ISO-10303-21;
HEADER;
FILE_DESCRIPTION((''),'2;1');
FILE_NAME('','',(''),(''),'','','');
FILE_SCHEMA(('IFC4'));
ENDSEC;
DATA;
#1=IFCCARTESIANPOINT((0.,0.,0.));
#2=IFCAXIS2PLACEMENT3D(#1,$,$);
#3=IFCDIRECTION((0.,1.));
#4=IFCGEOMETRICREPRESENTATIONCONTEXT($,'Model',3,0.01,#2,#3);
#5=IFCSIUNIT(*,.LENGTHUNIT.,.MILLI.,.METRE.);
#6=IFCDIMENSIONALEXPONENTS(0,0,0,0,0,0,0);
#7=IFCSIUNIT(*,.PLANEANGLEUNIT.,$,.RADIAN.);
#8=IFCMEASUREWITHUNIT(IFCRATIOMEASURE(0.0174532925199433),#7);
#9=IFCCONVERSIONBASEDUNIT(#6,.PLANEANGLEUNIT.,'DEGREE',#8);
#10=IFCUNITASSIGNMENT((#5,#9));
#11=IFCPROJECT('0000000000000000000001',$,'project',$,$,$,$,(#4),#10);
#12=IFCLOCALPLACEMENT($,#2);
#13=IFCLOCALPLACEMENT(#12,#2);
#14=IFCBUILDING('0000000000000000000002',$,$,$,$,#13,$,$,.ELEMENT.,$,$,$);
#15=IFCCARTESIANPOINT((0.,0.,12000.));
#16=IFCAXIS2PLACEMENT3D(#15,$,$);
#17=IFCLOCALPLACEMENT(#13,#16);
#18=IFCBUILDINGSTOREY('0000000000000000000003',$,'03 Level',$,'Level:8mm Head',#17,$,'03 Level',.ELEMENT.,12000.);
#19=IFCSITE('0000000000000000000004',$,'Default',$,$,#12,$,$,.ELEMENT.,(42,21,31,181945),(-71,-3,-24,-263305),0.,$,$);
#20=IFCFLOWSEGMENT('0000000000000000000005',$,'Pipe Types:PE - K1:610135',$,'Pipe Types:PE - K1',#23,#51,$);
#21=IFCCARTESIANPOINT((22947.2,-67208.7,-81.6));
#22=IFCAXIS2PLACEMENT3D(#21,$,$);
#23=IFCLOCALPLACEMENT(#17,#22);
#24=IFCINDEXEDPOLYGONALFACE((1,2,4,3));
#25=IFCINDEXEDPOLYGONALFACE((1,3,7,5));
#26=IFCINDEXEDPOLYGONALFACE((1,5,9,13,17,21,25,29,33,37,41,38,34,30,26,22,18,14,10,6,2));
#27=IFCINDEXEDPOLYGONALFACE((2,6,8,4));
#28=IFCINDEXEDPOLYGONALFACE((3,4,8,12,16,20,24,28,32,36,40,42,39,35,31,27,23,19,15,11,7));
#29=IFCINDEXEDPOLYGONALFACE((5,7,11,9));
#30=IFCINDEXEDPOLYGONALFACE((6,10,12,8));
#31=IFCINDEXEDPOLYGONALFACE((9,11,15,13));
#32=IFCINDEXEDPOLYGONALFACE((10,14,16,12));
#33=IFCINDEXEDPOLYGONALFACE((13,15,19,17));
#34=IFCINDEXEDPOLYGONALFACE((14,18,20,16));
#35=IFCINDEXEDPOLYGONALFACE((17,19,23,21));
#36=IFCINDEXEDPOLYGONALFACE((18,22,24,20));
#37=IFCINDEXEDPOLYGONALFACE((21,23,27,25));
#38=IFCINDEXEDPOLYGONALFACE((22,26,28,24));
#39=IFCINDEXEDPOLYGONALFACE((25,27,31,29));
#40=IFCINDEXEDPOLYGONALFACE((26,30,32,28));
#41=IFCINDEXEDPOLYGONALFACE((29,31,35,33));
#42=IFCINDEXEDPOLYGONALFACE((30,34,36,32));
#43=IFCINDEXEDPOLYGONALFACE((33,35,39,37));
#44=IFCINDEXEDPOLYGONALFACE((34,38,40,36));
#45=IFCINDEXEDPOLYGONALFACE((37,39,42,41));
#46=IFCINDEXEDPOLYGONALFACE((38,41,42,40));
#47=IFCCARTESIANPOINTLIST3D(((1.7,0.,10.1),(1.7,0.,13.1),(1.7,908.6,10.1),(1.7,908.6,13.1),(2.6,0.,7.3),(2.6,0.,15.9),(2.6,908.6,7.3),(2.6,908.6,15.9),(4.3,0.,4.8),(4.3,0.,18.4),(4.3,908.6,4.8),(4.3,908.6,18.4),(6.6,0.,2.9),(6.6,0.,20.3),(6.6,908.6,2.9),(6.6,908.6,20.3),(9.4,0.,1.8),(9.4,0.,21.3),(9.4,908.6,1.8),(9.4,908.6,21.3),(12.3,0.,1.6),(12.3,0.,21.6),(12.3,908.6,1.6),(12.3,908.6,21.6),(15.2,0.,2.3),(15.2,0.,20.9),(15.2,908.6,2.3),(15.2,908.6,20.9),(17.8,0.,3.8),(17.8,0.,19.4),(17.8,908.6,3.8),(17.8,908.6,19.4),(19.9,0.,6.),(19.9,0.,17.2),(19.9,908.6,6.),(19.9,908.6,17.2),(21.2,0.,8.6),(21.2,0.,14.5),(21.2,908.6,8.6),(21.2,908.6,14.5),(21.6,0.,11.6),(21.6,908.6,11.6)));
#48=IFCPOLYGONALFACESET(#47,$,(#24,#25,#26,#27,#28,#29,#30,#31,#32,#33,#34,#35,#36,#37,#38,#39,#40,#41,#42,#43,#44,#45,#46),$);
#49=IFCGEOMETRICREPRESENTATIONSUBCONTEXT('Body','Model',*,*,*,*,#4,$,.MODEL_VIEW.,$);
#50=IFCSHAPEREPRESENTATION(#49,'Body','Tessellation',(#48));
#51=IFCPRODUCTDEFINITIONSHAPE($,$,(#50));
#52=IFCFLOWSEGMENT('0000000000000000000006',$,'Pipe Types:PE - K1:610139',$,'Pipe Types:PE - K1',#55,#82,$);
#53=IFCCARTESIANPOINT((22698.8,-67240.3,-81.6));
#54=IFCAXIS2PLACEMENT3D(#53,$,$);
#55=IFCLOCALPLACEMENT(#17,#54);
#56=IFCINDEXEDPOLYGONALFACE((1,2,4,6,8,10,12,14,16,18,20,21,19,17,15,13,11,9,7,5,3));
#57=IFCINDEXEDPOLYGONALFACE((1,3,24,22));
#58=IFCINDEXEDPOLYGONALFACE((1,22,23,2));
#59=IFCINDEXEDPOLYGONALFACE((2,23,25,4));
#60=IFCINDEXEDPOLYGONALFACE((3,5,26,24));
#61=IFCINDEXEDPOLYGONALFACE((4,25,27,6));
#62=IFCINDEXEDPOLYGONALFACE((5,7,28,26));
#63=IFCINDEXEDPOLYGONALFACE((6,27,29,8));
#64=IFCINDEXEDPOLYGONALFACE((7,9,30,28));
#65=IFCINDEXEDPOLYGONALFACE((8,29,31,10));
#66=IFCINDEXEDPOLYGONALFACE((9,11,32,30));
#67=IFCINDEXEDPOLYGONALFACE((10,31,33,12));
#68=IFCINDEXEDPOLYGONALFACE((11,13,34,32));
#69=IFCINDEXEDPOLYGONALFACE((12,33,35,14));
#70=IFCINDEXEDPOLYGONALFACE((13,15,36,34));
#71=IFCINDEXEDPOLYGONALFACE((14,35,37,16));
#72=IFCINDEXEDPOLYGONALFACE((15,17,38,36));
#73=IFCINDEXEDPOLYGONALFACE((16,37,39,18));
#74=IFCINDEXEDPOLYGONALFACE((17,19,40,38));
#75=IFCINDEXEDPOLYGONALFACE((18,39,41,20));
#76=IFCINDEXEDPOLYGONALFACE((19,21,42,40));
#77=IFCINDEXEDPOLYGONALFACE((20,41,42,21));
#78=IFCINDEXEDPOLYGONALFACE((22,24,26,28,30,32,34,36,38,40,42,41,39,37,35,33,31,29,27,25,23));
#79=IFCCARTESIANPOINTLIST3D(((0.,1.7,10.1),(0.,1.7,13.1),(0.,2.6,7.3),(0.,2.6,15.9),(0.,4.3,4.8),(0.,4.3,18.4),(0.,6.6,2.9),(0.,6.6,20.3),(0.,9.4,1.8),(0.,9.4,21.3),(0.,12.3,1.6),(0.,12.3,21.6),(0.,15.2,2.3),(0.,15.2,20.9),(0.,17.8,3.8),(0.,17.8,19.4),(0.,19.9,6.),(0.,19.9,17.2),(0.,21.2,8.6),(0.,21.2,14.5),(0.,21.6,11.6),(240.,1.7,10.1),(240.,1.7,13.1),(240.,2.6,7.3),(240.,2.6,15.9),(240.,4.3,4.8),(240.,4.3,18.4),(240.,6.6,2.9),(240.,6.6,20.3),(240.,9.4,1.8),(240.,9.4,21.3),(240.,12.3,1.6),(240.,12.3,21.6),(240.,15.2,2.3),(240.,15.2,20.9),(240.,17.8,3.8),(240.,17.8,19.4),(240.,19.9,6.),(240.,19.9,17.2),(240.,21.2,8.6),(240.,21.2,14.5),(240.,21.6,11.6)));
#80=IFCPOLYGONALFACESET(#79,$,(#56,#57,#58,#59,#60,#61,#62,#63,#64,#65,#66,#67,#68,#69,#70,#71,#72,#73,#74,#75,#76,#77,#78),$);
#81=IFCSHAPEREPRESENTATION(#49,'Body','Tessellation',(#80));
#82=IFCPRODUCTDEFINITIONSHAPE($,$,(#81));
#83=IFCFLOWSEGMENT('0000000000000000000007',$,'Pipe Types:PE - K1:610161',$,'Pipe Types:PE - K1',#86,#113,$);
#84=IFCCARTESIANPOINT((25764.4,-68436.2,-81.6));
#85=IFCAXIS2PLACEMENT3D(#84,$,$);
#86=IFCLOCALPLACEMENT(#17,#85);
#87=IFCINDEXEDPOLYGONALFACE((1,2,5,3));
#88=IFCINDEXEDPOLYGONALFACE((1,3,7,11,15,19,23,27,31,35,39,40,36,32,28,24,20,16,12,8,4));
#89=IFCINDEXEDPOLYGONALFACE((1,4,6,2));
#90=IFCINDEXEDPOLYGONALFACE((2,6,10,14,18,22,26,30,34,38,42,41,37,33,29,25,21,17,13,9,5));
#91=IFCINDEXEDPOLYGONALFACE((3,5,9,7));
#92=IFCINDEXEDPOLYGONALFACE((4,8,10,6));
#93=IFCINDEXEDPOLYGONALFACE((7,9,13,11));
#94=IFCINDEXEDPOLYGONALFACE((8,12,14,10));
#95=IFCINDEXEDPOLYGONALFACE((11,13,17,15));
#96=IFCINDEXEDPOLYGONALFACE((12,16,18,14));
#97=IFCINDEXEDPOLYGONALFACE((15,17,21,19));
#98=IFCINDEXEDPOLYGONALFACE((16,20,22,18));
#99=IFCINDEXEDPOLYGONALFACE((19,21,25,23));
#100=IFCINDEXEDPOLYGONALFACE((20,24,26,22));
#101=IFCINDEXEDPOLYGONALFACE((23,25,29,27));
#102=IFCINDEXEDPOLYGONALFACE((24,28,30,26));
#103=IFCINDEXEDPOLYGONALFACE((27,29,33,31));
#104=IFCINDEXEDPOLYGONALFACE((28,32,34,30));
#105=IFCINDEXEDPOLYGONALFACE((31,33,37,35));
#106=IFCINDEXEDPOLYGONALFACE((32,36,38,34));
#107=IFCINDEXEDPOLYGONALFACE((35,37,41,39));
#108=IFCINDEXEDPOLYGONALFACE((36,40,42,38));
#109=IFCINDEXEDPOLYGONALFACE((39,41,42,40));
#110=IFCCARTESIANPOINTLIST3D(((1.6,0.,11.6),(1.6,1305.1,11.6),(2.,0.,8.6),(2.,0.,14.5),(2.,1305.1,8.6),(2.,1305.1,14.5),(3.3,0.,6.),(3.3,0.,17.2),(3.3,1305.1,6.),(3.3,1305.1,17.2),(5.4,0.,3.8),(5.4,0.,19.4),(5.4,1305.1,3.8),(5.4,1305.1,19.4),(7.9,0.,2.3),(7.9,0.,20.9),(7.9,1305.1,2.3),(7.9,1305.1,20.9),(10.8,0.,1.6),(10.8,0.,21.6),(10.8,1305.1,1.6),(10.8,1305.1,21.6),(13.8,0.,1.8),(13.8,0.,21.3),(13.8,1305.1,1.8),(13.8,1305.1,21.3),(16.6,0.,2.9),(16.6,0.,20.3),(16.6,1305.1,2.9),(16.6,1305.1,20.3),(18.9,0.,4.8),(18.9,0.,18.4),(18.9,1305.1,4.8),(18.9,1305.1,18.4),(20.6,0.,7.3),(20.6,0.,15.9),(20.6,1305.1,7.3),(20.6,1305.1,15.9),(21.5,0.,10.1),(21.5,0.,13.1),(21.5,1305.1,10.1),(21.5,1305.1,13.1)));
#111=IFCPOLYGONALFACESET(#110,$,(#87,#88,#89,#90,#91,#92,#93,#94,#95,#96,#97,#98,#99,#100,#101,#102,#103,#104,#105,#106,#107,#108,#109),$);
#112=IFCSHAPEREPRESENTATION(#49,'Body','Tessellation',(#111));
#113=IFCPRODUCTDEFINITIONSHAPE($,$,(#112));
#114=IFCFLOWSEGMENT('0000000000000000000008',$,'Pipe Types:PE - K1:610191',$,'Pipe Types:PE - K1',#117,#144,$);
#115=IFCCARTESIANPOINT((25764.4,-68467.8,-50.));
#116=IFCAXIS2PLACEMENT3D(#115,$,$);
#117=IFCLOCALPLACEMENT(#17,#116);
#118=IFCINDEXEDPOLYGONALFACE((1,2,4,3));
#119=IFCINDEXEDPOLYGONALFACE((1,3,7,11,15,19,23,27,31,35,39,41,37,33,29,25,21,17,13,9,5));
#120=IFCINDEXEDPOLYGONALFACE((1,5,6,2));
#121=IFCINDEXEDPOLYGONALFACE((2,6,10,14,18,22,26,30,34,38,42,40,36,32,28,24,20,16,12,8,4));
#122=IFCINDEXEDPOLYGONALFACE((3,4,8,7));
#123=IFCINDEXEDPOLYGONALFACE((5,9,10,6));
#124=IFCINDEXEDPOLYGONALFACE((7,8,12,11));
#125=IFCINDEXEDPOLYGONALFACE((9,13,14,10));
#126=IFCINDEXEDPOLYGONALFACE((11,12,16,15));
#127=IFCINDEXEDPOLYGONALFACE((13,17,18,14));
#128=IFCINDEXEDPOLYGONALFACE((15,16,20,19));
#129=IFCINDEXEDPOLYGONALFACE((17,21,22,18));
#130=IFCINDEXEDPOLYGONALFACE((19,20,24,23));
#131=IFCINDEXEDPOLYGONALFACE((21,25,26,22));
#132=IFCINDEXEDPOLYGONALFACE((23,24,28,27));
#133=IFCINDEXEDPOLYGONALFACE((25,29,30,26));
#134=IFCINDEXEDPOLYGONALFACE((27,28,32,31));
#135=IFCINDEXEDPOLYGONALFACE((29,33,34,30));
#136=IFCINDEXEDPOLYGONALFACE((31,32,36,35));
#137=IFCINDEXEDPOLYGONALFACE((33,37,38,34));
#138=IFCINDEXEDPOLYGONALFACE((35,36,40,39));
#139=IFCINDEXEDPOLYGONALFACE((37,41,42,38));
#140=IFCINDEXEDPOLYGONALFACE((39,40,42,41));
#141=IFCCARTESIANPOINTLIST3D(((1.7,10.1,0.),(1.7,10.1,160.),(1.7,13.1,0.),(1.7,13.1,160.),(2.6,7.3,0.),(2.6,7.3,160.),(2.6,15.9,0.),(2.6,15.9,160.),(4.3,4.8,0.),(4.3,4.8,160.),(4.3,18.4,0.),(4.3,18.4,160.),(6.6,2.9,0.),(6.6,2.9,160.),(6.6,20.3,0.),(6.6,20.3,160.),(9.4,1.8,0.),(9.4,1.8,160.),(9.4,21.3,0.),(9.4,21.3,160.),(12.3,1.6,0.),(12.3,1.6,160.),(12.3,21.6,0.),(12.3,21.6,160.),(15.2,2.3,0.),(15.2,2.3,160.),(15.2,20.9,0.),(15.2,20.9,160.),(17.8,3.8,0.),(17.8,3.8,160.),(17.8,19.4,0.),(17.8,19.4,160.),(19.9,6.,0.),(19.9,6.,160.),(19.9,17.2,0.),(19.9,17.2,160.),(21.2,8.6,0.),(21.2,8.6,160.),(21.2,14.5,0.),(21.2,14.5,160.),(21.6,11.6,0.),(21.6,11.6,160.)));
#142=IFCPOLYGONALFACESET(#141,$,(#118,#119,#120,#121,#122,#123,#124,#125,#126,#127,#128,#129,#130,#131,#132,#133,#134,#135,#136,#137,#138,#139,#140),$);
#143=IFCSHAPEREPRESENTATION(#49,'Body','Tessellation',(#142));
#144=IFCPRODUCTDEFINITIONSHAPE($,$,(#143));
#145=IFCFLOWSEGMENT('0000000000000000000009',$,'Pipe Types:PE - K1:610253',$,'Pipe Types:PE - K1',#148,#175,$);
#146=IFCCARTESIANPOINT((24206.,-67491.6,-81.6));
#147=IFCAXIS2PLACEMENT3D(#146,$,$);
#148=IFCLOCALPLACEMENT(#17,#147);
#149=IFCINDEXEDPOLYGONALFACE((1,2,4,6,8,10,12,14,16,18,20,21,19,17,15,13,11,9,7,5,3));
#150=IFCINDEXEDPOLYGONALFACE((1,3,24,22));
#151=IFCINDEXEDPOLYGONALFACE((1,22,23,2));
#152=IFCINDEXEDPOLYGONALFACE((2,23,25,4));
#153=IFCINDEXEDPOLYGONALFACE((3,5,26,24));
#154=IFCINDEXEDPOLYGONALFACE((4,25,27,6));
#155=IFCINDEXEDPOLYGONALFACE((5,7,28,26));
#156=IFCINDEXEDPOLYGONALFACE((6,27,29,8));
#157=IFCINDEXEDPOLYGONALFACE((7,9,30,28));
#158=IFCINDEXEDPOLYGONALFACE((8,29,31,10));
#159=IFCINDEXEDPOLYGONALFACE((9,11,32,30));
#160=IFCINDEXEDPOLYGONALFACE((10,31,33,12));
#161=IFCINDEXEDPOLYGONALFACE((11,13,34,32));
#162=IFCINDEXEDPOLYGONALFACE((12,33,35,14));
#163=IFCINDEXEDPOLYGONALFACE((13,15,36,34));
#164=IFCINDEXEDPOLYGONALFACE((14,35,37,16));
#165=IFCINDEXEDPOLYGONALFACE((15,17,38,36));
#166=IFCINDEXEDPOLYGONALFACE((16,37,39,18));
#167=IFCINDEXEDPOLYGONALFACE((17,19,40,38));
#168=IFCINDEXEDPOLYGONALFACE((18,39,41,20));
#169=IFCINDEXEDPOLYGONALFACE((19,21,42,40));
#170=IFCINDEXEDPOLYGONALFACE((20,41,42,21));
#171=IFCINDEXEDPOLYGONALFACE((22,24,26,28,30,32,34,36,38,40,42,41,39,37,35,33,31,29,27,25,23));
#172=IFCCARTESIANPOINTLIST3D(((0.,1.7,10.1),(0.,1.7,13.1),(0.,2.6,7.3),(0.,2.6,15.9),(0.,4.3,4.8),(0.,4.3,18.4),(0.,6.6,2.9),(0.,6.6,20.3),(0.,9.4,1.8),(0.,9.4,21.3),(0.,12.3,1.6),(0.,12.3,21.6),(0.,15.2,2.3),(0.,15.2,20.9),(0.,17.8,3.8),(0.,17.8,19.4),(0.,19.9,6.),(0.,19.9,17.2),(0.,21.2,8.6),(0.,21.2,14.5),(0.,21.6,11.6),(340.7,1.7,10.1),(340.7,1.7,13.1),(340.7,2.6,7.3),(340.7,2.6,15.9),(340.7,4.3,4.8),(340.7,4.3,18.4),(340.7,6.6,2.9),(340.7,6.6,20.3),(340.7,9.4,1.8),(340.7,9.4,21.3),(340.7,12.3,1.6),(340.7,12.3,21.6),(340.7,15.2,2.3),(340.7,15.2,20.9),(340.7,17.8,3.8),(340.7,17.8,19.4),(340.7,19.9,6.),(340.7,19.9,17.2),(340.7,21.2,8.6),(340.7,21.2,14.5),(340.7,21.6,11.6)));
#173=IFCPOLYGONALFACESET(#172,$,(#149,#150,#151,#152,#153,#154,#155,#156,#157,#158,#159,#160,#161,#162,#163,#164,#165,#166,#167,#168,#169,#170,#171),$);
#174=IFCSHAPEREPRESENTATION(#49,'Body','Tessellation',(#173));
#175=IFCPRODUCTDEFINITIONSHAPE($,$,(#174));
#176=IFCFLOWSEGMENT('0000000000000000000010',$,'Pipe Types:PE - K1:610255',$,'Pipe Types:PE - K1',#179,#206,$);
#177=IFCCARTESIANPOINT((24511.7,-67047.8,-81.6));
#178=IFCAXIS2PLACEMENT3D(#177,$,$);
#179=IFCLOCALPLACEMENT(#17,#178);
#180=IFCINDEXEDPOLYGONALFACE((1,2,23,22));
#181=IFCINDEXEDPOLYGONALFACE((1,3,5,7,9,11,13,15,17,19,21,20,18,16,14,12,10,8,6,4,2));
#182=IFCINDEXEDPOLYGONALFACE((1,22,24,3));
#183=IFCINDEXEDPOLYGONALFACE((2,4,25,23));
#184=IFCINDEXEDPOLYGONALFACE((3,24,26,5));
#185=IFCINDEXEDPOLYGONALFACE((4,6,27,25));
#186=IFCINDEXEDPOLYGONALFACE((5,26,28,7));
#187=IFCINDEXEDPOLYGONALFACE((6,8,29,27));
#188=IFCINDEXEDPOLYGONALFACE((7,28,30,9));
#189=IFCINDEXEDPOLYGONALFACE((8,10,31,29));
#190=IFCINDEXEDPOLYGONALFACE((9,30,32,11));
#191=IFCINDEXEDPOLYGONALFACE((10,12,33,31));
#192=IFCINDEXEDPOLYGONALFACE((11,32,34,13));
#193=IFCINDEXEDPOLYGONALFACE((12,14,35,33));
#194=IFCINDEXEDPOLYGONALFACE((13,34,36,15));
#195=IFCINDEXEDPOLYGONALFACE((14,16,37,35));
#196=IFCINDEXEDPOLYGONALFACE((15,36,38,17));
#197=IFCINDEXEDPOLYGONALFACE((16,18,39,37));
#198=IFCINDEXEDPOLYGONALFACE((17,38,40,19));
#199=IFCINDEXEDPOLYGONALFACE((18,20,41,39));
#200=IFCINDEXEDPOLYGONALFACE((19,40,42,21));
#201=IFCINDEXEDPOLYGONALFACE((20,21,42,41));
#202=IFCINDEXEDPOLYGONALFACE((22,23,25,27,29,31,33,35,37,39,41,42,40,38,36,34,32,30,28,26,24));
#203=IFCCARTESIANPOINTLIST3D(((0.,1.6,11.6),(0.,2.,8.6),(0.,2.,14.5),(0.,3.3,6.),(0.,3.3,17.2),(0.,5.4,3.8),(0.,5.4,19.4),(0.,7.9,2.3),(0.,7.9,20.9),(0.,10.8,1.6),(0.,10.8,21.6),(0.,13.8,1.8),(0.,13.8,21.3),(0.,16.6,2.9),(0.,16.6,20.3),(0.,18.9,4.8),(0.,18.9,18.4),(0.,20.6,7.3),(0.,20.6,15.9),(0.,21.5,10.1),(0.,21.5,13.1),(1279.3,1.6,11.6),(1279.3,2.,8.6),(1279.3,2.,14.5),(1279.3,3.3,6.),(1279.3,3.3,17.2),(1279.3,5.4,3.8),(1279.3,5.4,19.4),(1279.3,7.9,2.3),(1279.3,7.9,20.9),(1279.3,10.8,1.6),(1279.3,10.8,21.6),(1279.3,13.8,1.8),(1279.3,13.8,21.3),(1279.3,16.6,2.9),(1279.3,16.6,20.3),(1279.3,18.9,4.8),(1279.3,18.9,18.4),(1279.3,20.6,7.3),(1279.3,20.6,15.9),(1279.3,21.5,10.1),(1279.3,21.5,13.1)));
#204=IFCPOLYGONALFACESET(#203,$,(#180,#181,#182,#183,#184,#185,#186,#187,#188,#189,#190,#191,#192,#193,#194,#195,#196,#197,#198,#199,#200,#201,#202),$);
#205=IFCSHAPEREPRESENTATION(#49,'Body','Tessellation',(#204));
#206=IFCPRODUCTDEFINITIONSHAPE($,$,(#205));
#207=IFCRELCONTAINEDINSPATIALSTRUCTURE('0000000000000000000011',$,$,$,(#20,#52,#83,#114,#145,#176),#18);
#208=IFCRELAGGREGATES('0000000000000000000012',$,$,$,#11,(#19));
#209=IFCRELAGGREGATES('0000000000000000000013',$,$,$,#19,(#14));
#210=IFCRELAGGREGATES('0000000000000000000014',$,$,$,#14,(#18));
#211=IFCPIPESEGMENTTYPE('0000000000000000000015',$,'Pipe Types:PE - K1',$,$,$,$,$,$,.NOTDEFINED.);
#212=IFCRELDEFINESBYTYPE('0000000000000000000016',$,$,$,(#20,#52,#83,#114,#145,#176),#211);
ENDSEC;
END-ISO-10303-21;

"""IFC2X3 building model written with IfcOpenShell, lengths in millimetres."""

from ifc_helpers import new_model, entity, si_unit, converted_unit, direction, frame, frame_2d, origin, origin_2d_with_axis, place, context, subcontext, project, spatial, circle, extrude, type_object, element, save


model = new_model("IFC2X3")

# Units and contexts
model_context = context("Model", 3, precision=0.01, world=origin(), true_north=direction((0.0, 1.0)))
body_context = subcontext(model_context, "Body", "Model", "MODEL_VIEW")
ifc_project = project(units=[si_unit("LENGTHUNIT", "METRE", prefix="MILLI"), converted_unit("PLANEANGLEUNIT", "DEGREE", entity("IfcRatioMeasure", 0.0174532925199433), si_unit("PLANEANGLEUNIT", "RADIAN"), dimensions=[0, 0, 0, 0, 0, 0, 0])], contexts=[model_context])

# Site, building, storey
site_placement = place(None, origin())
site = spatial("IfcSite", under=ifc_project, at=site_placement, Name="Default", CompositionType="ELEMENT", RefLatitude=(42, 21, 31, 181945), RefLongitude=(-71, -3, -24, -263305), RefElevation=0.0)
building_placement = place(site_placement, origin())
building = spatial("IfcBuilding", under=site, at=building_placement, CompositionType="ELEMENT")
storey_placement = place(building_placement, frame((0.0, 0.0, 12000.0)))
storey = spatial("IfcBuildingStorey", under=building, at=storey_placement, Name="03 Level", ObjectType="Level:8mm Head", LongName="03 Level", CompositionType="ELEMENT", Elevation=12000.0)

# Flow segments
pipe_segment_type = type_object("IfcPipeSegmentType", Name="Pipe Types:PE - K1", PredefinedType="NOTDEFINED")
flow_segment_1_placement = place(storey_placement, frame((22947.2, -67208.7, -81.6)))
element("IfcFlowSegment", 1, at=flow_segment_1_placement, inside=storey, type_object=pipe_segment_type, Name="Pipe Types:PE - K1:610135", ObjectType="Pipe Types:PE - K1", context=body_context, shape_type="SweptSolid", body=[
    extrude(circle(Radius=10.0, at=frame_2d((0.0, 0.0), x_axis=(1.0, 0.0))), frame((11.6, 0.0, 11.6), z_axis=(0.0, 1.0, 0.0), x_axis=(1.0, 0.0, 0.0)), (0.0, 0.0, 1.0), 908.6),
])
flow_segment_2_placement = place(storey_placement, frame((22698.8, -67240.3, -81.6)))
element("IfcFlowSegment", 2, at=flow_segment_2_placement, inside=storey, type_object=pipe_segment_type, Name="Pipe Types:PE - K1:610139", ObjectType="Pipe Types:PE - K1", context=body_context, shape_type="SweptSolid", body=[
    extrude(circle(Radius=10.0, at=origin_2d_with_axis()), frame((0.0, 11.6, 11.6), z_axis=(1.0, 0.0, 0.0), x_axis=(0.0, 1.0, 0.0)), (0.0, 0.0, 1.0), 240.0),
])
flow_segment_3_placement = place(storey_placement, frame((25764.4, -68436.2, -81.6)))
element("IfcFlowSegment", 3, at=flow_segment_3_placement, inside=storey, type_object=pipe_segment_type, Name="Pipe Types:PE - K1:610161", ObjectType="Pipe Types:PE - K1", context=body_context, shape_type="SweptSolid", body=[
    extrude(circle(Radius=10.0, at=frame_2d((0.0, 0.0), x_axis=(1.0, 0.0))), frame((11.6, 0.0, 11.6), z_axis=(0.0, 1.0, 0.0), x_axis=(-1.0, 0.0, 0.0)), (0.0, 0.0, 1.0), 1305.1),
])
flow_segment_4_placement = place(storey_placement, frame((25764.4, -68467.8, -50.0)))
element("IfcFlowSegment", 4, at=flow_segment_4_placement, inside=storey, type_object=pipe_segment_type, Name="Pipe Types:PE - K1:610191", ObjectType="Pipe Types:PE - K1", context=body_context, shape_type="SweptSolid", body=[
    extrude(circle(Radius=10.0, at=origin_2d_with_axis()), frame((11.6, 11.6, 0.0)), (0.0, 0.0, 1.0), 160.0),
])
flow_segment_5_placement = place(storey_placement, frame((24206.0, -67491.6, -81.6)))
element("IfcFlowSegment", 5, at=flow_segment_5_placement, inside=storey, type_object=pipe_segment_type, Name="Pipe Types:PE - K1:610253", ObjectType="Pipe Types:PE - K1", context=body_context, shape_type="SweptSolid", body=[
    extrude(circle(Radius=10.0, at=frame_2d((0.0, 0.0), x_axis=(1.0, 0.0))), frame((0.0, 11.6, 11.6), z_axis=(1.0, 0.0, 0.0), x_axis=(0.0, 1.0, 0.0)), (0.0, 0.0, 1.0), 340.7),
])
flow_segment_6_placement = place(storey_placement, frame((24511.7, -67047.8, -81.6)))
element("IfcFlowSegment", 6, at=flow_segment_6_placement, inside=storey, type_object=pipe_segment_type, Name="Pipe Types:PE - K1:610255", ObjectType="Pipe Types:PE - K1", context=body_context, shape_type="SweptSolid", body=[
    extrude(circle(Radius=10.0, at=origin_2d_with_axis()), frame((0.0, 11.6, 11.6), z_axis=(1.0, 0.0, 0.0), x_axis=(0.0, -1.0, 0.0)), (0.0, 0.0, 1.0), 1279.3),
])

save(model, "model.ifc")
